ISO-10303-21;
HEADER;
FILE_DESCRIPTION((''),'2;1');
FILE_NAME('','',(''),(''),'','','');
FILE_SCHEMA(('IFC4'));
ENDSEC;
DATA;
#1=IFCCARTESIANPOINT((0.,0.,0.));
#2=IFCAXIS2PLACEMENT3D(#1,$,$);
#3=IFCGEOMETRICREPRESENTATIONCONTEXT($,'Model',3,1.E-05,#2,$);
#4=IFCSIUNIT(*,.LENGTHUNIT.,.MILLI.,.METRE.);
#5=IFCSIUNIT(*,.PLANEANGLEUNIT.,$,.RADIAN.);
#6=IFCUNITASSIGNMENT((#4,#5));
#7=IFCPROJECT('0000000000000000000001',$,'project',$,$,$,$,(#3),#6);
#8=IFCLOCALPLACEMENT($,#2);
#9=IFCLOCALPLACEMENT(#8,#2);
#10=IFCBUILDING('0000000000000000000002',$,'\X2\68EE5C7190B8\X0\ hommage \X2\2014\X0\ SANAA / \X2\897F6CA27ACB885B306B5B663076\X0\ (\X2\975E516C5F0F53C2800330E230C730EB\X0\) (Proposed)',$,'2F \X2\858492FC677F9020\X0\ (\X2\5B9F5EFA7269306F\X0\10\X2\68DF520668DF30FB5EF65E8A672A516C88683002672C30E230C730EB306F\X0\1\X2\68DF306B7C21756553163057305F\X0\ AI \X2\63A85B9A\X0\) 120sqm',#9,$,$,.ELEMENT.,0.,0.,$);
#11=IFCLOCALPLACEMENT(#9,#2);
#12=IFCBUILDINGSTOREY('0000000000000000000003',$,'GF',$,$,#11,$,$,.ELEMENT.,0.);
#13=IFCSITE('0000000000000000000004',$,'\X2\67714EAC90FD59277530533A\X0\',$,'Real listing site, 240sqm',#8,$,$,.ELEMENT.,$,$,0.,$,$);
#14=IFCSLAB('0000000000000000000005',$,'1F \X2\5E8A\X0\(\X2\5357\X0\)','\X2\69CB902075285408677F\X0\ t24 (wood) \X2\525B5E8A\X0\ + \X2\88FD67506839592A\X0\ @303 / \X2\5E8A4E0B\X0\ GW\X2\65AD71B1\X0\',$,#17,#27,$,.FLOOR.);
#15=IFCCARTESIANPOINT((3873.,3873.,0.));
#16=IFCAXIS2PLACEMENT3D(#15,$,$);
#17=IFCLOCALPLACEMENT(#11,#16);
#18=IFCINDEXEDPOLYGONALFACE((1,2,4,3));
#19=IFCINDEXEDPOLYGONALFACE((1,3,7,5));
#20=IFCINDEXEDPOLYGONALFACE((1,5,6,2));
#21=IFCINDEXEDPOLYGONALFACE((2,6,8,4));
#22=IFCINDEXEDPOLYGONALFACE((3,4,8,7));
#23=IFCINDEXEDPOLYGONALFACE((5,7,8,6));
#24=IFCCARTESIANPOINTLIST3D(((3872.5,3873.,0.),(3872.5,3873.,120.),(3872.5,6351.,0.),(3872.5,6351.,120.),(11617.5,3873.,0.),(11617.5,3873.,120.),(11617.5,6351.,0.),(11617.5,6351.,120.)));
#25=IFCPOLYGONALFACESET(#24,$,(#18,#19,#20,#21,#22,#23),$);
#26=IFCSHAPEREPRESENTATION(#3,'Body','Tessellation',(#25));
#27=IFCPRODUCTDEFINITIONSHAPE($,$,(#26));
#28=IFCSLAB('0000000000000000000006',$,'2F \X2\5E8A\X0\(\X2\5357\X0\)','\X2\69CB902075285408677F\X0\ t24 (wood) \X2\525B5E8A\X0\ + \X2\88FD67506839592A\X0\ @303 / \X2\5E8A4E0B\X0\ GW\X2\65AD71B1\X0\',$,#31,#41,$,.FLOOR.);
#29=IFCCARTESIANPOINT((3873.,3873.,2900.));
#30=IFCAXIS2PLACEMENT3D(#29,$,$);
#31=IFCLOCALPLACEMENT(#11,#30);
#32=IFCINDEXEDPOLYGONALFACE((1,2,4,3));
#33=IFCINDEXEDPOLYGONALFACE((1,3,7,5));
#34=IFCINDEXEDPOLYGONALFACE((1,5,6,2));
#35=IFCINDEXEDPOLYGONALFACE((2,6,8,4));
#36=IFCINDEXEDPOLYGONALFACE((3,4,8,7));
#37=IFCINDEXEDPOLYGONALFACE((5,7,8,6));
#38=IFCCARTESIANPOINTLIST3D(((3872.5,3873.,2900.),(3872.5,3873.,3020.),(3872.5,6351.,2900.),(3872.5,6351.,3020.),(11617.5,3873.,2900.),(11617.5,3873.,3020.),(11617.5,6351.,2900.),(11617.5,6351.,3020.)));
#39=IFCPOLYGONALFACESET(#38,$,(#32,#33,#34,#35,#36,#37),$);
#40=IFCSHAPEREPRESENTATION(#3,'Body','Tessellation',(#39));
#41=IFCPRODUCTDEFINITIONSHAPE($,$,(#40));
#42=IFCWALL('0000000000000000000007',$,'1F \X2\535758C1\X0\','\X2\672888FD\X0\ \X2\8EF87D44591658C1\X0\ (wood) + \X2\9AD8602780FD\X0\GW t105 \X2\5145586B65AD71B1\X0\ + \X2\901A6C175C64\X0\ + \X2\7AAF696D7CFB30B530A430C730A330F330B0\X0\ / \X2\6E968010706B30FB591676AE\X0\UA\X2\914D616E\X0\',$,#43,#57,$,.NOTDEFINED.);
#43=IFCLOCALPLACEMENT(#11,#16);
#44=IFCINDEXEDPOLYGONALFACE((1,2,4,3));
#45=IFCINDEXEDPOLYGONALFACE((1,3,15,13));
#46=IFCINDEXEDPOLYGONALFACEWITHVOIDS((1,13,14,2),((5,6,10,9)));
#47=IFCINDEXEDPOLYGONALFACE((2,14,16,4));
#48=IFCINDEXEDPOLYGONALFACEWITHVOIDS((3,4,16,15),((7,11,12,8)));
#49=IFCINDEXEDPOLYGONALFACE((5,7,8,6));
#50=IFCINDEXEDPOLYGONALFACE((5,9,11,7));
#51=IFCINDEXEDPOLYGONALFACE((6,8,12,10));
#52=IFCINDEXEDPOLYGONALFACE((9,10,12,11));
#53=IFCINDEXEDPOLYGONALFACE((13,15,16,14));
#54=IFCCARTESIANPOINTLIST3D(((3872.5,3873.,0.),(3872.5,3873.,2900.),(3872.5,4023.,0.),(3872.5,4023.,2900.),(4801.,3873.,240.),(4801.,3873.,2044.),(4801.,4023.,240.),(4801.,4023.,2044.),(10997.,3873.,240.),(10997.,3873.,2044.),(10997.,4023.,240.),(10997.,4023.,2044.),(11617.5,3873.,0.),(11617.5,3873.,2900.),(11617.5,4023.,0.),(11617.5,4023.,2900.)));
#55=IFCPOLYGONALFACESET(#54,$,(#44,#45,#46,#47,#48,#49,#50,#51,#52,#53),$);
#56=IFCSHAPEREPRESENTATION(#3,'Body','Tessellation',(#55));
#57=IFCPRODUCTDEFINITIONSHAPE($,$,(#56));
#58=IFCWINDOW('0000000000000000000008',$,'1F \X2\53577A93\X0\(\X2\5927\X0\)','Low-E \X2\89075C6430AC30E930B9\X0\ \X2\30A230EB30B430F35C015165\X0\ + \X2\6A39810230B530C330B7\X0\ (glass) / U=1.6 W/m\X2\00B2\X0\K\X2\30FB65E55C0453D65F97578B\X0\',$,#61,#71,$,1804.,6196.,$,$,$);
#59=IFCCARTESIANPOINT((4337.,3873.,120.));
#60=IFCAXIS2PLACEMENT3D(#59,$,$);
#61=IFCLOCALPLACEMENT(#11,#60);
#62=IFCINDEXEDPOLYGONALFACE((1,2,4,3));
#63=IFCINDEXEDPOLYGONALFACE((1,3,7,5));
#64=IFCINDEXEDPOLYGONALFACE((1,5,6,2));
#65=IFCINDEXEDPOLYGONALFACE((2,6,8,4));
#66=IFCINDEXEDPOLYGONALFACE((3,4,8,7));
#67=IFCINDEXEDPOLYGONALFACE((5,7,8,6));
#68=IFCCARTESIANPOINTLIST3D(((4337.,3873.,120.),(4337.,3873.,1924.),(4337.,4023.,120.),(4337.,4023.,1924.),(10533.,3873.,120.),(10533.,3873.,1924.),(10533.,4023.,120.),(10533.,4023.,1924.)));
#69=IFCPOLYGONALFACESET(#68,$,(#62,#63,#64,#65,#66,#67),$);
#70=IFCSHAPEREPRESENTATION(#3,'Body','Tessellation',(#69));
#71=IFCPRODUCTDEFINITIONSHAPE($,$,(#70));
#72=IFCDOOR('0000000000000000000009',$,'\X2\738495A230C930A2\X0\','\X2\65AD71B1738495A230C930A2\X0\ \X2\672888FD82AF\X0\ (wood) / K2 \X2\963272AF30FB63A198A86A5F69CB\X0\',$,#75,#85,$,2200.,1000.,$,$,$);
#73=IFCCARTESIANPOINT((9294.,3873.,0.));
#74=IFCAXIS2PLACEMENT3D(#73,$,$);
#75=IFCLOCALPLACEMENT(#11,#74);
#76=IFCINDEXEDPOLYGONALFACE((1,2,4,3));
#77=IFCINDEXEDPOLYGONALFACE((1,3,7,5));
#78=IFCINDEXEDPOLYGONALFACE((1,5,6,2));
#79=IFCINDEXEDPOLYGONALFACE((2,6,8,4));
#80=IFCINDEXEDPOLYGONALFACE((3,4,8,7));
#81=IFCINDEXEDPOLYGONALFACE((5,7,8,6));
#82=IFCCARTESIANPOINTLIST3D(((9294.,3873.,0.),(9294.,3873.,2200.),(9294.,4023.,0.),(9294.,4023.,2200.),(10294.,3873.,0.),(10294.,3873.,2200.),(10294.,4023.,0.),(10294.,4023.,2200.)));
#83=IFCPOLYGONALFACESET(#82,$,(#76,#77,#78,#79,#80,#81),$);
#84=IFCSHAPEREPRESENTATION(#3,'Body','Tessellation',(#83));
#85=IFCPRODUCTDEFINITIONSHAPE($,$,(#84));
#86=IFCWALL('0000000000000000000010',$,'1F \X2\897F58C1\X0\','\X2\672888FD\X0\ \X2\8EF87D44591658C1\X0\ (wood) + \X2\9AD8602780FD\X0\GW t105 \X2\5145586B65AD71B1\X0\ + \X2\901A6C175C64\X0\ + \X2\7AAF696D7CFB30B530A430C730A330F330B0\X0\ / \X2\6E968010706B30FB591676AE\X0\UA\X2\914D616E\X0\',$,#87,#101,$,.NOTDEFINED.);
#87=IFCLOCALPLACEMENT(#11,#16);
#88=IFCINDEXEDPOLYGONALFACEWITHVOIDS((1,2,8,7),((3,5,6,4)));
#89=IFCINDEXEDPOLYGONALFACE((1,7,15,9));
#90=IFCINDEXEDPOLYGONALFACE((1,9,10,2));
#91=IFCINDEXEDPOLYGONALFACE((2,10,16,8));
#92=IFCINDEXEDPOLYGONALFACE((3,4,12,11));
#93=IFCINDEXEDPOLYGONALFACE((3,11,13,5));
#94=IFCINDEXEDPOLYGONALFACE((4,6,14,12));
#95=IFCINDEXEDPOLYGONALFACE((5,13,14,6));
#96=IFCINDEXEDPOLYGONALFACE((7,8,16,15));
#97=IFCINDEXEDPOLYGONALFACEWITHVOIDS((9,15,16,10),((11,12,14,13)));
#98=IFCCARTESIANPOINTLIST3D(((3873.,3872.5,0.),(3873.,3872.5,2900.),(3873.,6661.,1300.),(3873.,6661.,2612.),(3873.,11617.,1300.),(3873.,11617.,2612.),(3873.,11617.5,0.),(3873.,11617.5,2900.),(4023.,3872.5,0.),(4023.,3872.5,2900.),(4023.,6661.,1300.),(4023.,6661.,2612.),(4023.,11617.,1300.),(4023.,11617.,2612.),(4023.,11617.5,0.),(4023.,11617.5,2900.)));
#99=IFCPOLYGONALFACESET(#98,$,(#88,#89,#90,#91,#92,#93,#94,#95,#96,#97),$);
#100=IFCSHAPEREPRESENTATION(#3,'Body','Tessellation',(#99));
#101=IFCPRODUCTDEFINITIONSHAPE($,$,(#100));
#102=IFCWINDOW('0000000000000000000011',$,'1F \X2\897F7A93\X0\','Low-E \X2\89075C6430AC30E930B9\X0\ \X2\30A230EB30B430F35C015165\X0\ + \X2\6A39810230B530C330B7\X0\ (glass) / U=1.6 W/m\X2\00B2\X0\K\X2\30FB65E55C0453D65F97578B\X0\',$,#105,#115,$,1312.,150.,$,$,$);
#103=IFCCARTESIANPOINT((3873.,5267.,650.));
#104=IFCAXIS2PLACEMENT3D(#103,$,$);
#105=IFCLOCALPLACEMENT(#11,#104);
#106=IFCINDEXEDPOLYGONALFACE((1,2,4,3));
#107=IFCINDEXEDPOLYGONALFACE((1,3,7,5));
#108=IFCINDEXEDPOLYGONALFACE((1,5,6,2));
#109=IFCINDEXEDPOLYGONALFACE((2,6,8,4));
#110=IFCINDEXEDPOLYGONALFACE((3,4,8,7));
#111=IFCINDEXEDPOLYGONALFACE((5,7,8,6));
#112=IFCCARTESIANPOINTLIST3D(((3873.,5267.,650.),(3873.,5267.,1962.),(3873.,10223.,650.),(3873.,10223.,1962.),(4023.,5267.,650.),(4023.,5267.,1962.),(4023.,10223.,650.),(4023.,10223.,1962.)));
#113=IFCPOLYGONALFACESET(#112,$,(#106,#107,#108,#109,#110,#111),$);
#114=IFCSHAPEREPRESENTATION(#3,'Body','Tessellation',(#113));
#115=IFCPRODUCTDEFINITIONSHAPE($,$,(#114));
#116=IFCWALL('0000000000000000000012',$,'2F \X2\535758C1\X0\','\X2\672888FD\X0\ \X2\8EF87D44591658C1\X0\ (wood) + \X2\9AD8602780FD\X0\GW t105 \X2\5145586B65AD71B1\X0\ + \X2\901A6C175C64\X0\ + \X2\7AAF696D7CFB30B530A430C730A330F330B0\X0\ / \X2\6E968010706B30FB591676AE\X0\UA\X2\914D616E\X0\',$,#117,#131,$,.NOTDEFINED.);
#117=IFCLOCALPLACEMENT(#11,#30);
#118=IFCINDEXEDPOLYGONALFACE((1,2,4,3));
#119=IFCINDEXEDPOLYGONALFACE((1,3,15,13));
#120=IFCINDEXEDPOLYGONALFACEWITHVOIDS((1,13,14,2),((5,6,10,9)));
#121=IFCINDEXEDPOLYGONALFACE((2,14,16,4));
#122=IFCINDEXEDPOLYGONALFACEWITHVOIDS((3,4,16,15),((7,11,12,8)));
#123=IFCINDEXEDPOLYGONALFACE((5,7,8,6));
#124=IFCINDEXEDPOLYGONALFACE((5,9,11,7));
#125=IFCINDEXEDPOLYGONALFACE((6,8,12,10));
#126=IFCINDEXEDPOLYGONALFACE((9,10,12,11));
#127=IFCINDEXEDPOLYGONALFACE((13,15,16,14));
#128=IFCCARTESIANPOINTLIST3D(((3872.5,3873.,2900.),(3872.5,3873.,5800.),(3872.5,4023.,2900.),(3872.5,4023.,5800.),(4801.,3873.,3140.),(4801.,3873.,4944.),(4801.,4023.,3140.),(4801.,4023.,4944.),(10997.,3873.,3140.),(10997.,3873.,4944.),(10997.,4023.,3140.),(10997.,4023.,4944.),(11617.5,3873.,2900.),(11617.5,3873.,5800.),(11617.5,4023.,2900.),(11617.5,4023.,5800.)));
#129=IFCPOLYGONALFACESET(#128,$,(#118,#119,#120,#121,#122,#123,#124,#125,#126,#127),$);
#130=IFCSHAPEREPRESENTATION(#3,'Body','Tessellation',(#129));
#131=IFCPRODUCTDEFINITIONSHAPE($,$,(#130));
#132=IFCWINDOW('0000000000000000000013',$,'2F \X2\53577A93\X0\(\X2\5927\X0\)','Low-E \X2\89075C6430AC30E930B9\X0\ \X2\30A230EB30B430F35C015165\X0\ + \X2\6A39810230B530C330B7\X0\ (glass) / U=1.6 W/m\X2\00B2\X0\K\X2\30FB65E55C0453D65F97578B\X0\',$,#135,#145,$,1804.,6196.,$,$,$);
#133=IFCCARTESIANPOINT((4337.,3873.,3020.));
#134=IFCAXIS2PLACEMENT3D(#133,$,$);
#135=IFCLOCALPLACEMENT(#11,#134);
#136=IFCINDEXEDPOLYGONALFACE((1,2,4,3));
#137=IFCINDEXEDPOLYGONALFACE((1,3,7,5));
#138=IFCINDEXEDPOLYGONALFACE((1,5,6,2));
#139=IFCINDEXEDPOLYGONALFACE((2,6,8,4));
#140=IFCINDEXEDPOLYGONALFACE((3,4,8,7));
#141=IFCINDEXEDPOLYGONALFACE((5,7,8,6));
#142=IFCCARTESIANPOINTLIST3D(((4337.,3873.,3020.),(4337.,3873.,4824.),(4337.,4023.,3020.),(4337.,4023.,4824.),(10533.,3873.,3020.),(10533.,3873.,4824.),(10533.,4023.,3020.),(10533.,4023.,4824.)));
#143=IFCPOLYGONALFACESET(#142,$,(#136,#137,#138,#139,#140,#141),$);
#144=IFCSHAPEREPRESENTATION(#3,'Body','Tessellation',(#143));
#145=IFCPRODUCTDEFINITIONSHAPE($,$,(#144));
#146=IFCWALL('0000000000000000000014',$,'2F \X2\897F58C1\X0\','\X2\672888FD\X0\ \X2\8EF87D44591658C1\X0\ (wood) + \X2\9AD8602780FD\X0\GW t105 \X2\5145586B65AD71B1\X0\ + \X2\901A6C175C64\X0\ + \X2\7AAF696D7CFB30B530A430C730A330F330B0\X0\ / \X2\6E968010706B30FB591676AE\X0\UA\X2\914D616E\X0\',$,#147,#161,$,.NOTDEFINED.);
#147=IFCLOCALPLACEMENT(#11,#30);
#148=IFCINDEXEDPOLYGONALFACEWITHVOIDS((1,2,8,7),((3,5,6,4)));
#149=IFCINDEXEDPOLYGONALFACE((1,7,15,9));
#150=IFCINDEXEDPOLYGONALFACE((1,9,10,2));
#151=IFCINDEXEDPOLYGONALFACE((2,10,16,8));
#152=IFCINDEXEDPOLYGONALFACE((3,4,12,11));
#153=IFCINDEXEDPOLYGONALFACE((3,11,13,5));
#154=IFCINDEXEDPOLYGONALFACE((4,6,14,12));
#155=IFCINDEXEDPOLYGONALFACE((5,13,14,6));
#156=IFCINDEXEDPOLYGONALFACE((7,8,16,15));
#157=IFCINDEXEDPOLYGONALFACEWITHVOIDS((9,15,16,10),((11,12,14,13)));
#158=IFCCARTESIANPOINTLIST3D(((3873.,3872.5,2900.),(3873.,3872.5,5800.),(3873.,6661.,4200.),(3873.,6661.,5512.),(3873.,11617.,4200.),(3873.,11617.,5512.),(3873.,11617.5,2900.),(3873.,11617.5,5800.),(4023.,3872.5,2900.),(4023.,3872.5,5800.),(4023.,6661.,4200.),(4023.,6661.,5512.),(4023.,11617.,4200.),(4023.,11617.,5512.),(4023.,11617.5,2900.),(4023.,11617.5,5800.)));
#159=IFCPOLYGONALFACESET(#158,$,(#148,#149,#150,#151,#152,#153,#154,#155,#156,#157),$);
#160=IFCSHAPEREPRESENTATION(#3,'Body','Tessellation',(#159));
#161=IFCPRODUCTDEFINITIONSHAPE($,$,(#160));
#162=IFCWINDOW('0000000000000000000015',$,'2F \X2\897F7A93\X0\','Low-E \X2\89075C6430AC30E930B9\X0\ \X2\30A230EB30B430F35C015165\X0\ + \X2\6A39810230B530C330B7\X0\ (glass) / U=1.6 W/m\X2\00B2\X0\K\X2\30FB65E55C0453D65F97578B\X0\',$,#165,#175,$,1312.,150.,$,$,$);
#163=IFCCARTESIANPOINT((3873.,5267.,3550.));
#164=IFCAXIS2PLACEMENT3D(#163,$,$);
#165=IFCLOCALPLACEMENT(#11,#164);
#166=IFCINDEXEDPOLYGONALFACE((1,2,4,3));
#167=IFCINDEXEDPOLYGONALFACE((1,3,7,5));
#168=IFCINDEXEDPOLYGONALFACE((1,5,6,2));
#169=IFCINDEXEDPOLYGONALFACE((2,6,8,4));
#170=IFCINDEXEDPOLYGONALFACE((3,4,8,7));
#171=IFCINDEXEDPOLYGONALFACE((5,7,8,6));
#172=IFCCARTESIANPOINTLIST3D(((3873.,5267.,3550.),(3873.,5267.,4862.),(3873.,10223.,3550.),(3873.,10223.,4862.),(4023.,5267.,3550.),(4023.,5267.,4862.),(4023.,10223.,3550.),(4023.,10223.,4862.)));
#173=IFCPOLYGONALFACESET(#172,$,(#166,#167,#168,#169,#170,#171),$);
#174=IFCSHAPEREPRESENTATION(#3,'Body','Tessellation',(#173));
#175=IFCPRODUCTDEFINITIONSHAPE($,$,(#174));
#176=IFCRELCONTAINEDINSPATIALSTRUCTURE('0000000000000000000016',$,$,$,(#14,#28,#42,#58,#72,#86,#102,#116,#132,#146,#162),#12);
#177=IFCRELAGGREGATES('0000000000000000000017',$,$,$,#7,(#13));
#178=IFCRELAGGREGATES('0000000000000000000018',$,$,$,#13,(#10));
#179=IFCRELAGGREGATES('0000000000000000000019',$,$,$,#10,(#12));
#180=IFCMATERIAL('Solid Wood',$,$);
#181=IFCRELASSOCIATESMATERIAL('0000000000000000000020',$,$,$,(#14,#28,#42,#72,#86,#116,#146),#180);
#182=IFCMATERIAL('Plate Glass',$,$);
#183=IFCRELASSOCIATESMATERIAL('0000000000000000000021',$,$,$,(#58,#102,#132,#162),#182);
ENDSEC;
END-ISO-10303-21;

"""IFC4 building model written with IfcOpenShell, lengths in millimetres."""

from ifc_helpers import new_model, si_unit, frame, frame_2d, origin, place, context, project, spatial, rectangle, extrude, material, element, fill, save


model = new_model("IFC4")

# Units and contexts
model_context = context("Model", 3, precision=1e-05, world=origin())
ifc_project = project(units=[si_unit("LENGTHUNIT", "METRE", prefix="MILLI"), si_unit("PLANEANGLEUNIT", "RADIAN")], contexts=[model_context])

# Site, building, storey
site_placement = place(None, origin())
site = spatial("IfcSite", under=ifc_project, at=site_placement, Name="東京都大田区", ObjectType="Real listing site, 240sqm", CompositionType="ELEMENT", RefElevation=0.0)
building_placement = place(site_placement, origin())
building = spatial("IfcBuilding", under=site, at=building_placement, Name="森山邸 hommage — SANAA / 西沢立衛に学ぶ (非公式参考モデル) (Proposed)", ObjectType="2F 薄鋼板造 (実建物は10棟分棟・延床未公表。本モデルは1棟に簡略化した AI 推定) 120sqm", CompositionType="ELEMENT", ElevationOfRefHeight=0.0, ElevationOfTerrain=0.0)
storey_placement = place(building_placement, origin())
storey = spatial("IfcBuildingStorey", under=building, at=storey_placement, Name="GF", CompositionType="ELEMENT", Elevation=0.0)

# Slabs
ifc_material_1 = material(Name="Solid Wood")
slab_1_placement = place(storey_placement, frame((3873.0, 3873.0, 0.0)))
element("IfcSlab", 1, at=slab_1_placement, inside=storey, material=ifc_material_1, Name="1F 床(南)", Description="構造用合板 t24 (wood) 剛床 + 製材根太 @303 / 床下 GW断熱", PredefinedType="FLOOR", context=model_context, shape_type="SweptSolid", body=[
    extrude(rectangle(XDim=7745.0, YDim=2478.0, at=frame_2d((3872.0, 1239.0))), frame((3873.0, 3873.0, 0.0)), (0.0, 0.0, 1.0), 120.0),
])
slab_2_placement = place(storey_placement, frame((3873.0, 3873.0, 2900.0)))
element("IfcSlab", 2, at=slab_2_placement, inside=storey, material=ifc_material_1, Name="2F 床(南)", Description="構造用合板 t24 (wood) 剛床 + 製材根太 @303 / 床下 GW断熱", PredefinedType="FLOOR", context=model_context, shape_type="SweptSolid", body=[
    extrude(rectangle(XDim=7745.0, YDim=2478.0, at=frame_2d((3872.0, 1239.0))), frame((3873.0, 3873.0, 2900.0)), (0.0, 0.0, 1.0), 120.0),
])

# Wall, openings, window, door
wall_1_placement = place(storey_placement, frame((3873.0, 3873.0, 0.0)))
wall_1 = element("IfcWall", 3, at=wall_1_placement, inside=storey, material=ifc_material_1, Name="1F 南壁", Description="木製 軸組外壁 (wood) + 高性能GW t105 充填断熱 + 通気層 + 窯業系サイディング / 準耐火・外皮UA配慮", PredefinedType="NOTDEFINED", context=model_context, shape_type="SweptSolid", body=[
    extrude(rectangle(XDim=7745.0, YDim=150.0, at=frame_2d((3872.0, 75.0))), frame((3873.0, 3873.0, 0.0)), (0.0, 0.0, 1.0), 2900.0),
])
opening_1_placement = place(storey_placement, frame((4337.0, 3873.0, 120.0)))
opening_1 = element("IfcOpeningElement", 4, at=opening_1_placement, cuts=wall_1, PredefinedType="NOTDEFINED", context=model_context, shape_type="SweptSolid", body=[
    extrude(rectangle(XDim=6196.0, YDim=150.0, at=frame_2d((3098.0, 75.0))), frame((4337.0, 3873.0, 120.0)), (0.0, 0.0, 1.0), 1804.0),
])
opening_2_placement = place(storey_placement, frame((9294.0, 3873.0, 0.0)))
opening_2 = element("IfcOpeningElement", 5, at=opening_2_placement, cuts=wall_1, PredefinedType="NOTDEFINED", context=model_context, shape_type="SweptSolid", body=[
    extrude(rectangle(XDim=1000.0, YDim=150.0, at=frame_2d((500.0, 75.0))), frame((9294.0, 3873.0, 0.0)), (0.0, 0.0, 1.0), 2200.0),
])
ifc_material_2 = material(Name="Plate Glass")
window_1_placement = place(storey_placement, frame((4337.0, 3873.0, 120.0)))
window_1 = element("IfcWindow", 6, at=window_1_placement, inside=storey, material=ifc_material_2, Name="1F 南窓(大)", Description="Low-E 複層ガラス アルゴン封入 + 樹脂サッシ (glass) / U=1.6 W/m²K・日射取得型", OverallHeight=1804.0, OverallWidth=6196.0, context=model_context, shape_type="SweptSolid", body=[
    extrude(rectangle(XDim=6196.0, YDim=150.0, at=frame_2d((3098.0, 75.0))), frame((4337.0, 3873.0, 120.0)), (0.0, 0.0, 1.0), 1804.0),
])
fill(opening_1, window_1)
door_placement = place(storey_placement, frame((9294.0, 3873.0, 0.0)))
door = element("IfcDoor", 7, at=door_placement, inside=storey, material=ifc_material_1, Name="玄関ドア", Description="断熱玄関ドア 木製芯 (wood) / K2 防犯・採風機構", OverallHeight=2200.0, OverallWidth=1000.0, context=model_context, shape_type="SweptSolid", body=[
    extrude(rectangle(XDim=1000.0, YDim=150.0, at=frame_2d((500.0, 75.0))), frame((9294.0, 3873.0, 0.0)), (0.0, 0.0, 1.0), 2200.0),
])
fill(opening_2, door)

# Walls, openings, windows
wall_2_placement = place(storey_placement, frame((3873.0, 3873.0, 0.0)))
wall_2 = element("IfcWall", 8, at=wall_2_placement, inside=storey, material=ifc_material_1, Name="1F 西壁", Description="木製 軸組外壁 (wood) + 高性能GW t105 充填断熱 + 通気層 + 窯業系サイディング / 準耐火・外皮UA配慮", PredefinedType="NOTDEFINED", context=model_context, shape_type="SweptSolid", body=[
    extrude(rectangle(XDim=150.0, YDim=7745.0, at=frame_2d((75.0, 3872.0))), frame((3873.0, 3873.0, 0.0)), (0.0, 0.0, 1.0), 2900.0),
])
opening_3_placement = place(storey_placement, frame((3873.0, 5267.0, 650.0)))
opening_3 = element("IfcOpeningElement", 9, at=opening_3_placement, cuts=wall_2, PredefinedType="NOTDEFINED", context=model_context, shape_type="SweptSolid", body=[
    extrude(rectangle(XDim=150.0, YDim=4956.0, at=frame_2d((75.0, 2478.0))), frame((3873.0, 5267.0, 650.0)), (0.0, 0.0, 1.0), 1312.0),
])
window_2_placement = place(storey_placement, frame((3873.0, 5267.0, 650.0)))
window_2 = element("IfcWindow", 10, at=window_2_placement, inside=storey, material=ifc_material_2, Name="1F 西窓", Description="Low-E 複層ガラス アルゴン封入 + 樹脂サッシ (glass) / U=1.6 W/m²K・日射取得型", OverallHeight=1312.0, OverallWidth=150.0, context=model_context, shape_type="SweptSolid", body=[
    extrude(rectangle(XDim=150.0, YDim=4956.0, at=frame_2d((75.0, 2478.0))), frame((3873.0, 5267.0, 650.0)), (0.0, 0.0, 1.0), 1312.0),
])
fill(opening_3, window_2)
wall_3_placement = place(storey_placement, frame((3873.0, 3873.0, 2900.0)))
wall_3 = element("IfcWall", 11, at=wall_3_placement, inside=storey, material=ifc_material_1, Name="2F 南壁", Description="木製 軸組外壁 (wood) + 高性能GW t105 充填断熱 + 通気層 + 窯業系サイディング / 準耐火・外皮UA配慮", PredefinedType="NOTDEFINED", context=model_context, shape_type="SweptSolid", body=[
    extrude(rectangle(XDim=7745.0, YDim=150.0, at=frame_2d((3872.0, 75.0))), frame((3873.0, 3873.0, 2900.0)), (0.0, 0.0, 1.0), 2900.0),
])
opening_4_placement = place(storey_placement, frame((4337.0, 3873.0, 3020.0)))
opening_4 = element("IfcOpeningElement", 12, at=opening_4_placement, cuts=wall_3, PredefinedType="NOTDEFINED", context=model_context, shape_type="SweptSolid", body=[
    extrude(rectangle(XDim=6196.0, YDim=150.0, at=frame_2d((3098.0, 75.0))), frame((4337.0, 3873.0, 3020.0)), (0.0, 0.0, 1.0), 1804.0),
])
window_3_placement = place(storey_placement, frame((4337.0, 3873.0, 3020.0)))
window_3 = element("IfcWindow", 13, at=window_3_placement, inside=storey, material=ifc_material_2, Name="2F 南窓(大)", Description="Low-E 複層ガラス アルゴン封入 + 樹脂サッシ (glass) / U=1.6 W/m²K・日射取得型", OverallHeight=1804.0, OverallWidth=6196.0, context=model_context, shape_type="SweptSolid", body=[
    extrude(rectangle(XDim=6196.0, YDim=150.0, at=frame_2d((3098.0, 75.0))), frame((4337.0, 3873.0, 3020.0)), (0.0, 0.0, 1.0), 1804.0),
])
fill(opening_4, window_3)
wall_4_placement = place(storey_placement, frame((3873.0, 3873.0, 2900.0)))
wall_4 = element("IfcWall", 14, at=wall_4_placement, inside=storey, material=ifc_material_1, Name="2F 西壁", Description="木製 軸組外壁 (wood) + 高性能GW t105 充填断熱 + 通気層 + 窯業系サイディング / 準耐火・外皮UA配慮", PredefinedType="NOTDEFINED", context=model_context, shape_type="SweptSolid", body=[
    extrude(rectangle(XDim=150.0, YDim=7745.0, at=frame_2d((75.0, 3872.0))), frame((3873.0, 3873.0, 2900.0)), (0.0, 0.0, 1.0), 2900.0),
])
opening_5_placement = place(storey_placement, frame((3873.0, 5267.0, 3550.0)))
opening_5 = element("IfcOpeningElement", 15, at=opening_5_placement, cuts=wall_4, PredefinedType="NOTDEFINED", context=model_context, shape_type="SweptSolid", body=[
    extrude(rectangle(XDim=150.0, YDim=4956.0, at=frame_2d((75.0, 2478.0))), frame((3873.0, 5267.0, 3550.0)), (0.0, 0.0, 1.0), 1312.0),
])
window_4_placement = place(storey_placement, frame((3873.0, 5267.0, 3550.0)))
window_4 = element("IfcWindow", 16, at=window_4_placement, inside=storey, material=ifc_material_2, Name="2F 西窓", Description="Low-E 複層ガラス アルゴン封入 + 樹脂サッシ (glass) / U=1.6 W/m²K・日射取得型", OverallHeight=1312.0, OverallWidth=150.0, context=model_context, shape_type="SweptSolid", body=[
    extrude(rectangle(XDim=150.0, YDim=4956.0, at=frame_2d((75.0, 2478.0))), frame((3873.0, 5267.0, 3550.0)), (0.0, 0.0, 1.0), 1312.0),
])
fill(opening_5, window_4)

save(model, "model.ifc")
